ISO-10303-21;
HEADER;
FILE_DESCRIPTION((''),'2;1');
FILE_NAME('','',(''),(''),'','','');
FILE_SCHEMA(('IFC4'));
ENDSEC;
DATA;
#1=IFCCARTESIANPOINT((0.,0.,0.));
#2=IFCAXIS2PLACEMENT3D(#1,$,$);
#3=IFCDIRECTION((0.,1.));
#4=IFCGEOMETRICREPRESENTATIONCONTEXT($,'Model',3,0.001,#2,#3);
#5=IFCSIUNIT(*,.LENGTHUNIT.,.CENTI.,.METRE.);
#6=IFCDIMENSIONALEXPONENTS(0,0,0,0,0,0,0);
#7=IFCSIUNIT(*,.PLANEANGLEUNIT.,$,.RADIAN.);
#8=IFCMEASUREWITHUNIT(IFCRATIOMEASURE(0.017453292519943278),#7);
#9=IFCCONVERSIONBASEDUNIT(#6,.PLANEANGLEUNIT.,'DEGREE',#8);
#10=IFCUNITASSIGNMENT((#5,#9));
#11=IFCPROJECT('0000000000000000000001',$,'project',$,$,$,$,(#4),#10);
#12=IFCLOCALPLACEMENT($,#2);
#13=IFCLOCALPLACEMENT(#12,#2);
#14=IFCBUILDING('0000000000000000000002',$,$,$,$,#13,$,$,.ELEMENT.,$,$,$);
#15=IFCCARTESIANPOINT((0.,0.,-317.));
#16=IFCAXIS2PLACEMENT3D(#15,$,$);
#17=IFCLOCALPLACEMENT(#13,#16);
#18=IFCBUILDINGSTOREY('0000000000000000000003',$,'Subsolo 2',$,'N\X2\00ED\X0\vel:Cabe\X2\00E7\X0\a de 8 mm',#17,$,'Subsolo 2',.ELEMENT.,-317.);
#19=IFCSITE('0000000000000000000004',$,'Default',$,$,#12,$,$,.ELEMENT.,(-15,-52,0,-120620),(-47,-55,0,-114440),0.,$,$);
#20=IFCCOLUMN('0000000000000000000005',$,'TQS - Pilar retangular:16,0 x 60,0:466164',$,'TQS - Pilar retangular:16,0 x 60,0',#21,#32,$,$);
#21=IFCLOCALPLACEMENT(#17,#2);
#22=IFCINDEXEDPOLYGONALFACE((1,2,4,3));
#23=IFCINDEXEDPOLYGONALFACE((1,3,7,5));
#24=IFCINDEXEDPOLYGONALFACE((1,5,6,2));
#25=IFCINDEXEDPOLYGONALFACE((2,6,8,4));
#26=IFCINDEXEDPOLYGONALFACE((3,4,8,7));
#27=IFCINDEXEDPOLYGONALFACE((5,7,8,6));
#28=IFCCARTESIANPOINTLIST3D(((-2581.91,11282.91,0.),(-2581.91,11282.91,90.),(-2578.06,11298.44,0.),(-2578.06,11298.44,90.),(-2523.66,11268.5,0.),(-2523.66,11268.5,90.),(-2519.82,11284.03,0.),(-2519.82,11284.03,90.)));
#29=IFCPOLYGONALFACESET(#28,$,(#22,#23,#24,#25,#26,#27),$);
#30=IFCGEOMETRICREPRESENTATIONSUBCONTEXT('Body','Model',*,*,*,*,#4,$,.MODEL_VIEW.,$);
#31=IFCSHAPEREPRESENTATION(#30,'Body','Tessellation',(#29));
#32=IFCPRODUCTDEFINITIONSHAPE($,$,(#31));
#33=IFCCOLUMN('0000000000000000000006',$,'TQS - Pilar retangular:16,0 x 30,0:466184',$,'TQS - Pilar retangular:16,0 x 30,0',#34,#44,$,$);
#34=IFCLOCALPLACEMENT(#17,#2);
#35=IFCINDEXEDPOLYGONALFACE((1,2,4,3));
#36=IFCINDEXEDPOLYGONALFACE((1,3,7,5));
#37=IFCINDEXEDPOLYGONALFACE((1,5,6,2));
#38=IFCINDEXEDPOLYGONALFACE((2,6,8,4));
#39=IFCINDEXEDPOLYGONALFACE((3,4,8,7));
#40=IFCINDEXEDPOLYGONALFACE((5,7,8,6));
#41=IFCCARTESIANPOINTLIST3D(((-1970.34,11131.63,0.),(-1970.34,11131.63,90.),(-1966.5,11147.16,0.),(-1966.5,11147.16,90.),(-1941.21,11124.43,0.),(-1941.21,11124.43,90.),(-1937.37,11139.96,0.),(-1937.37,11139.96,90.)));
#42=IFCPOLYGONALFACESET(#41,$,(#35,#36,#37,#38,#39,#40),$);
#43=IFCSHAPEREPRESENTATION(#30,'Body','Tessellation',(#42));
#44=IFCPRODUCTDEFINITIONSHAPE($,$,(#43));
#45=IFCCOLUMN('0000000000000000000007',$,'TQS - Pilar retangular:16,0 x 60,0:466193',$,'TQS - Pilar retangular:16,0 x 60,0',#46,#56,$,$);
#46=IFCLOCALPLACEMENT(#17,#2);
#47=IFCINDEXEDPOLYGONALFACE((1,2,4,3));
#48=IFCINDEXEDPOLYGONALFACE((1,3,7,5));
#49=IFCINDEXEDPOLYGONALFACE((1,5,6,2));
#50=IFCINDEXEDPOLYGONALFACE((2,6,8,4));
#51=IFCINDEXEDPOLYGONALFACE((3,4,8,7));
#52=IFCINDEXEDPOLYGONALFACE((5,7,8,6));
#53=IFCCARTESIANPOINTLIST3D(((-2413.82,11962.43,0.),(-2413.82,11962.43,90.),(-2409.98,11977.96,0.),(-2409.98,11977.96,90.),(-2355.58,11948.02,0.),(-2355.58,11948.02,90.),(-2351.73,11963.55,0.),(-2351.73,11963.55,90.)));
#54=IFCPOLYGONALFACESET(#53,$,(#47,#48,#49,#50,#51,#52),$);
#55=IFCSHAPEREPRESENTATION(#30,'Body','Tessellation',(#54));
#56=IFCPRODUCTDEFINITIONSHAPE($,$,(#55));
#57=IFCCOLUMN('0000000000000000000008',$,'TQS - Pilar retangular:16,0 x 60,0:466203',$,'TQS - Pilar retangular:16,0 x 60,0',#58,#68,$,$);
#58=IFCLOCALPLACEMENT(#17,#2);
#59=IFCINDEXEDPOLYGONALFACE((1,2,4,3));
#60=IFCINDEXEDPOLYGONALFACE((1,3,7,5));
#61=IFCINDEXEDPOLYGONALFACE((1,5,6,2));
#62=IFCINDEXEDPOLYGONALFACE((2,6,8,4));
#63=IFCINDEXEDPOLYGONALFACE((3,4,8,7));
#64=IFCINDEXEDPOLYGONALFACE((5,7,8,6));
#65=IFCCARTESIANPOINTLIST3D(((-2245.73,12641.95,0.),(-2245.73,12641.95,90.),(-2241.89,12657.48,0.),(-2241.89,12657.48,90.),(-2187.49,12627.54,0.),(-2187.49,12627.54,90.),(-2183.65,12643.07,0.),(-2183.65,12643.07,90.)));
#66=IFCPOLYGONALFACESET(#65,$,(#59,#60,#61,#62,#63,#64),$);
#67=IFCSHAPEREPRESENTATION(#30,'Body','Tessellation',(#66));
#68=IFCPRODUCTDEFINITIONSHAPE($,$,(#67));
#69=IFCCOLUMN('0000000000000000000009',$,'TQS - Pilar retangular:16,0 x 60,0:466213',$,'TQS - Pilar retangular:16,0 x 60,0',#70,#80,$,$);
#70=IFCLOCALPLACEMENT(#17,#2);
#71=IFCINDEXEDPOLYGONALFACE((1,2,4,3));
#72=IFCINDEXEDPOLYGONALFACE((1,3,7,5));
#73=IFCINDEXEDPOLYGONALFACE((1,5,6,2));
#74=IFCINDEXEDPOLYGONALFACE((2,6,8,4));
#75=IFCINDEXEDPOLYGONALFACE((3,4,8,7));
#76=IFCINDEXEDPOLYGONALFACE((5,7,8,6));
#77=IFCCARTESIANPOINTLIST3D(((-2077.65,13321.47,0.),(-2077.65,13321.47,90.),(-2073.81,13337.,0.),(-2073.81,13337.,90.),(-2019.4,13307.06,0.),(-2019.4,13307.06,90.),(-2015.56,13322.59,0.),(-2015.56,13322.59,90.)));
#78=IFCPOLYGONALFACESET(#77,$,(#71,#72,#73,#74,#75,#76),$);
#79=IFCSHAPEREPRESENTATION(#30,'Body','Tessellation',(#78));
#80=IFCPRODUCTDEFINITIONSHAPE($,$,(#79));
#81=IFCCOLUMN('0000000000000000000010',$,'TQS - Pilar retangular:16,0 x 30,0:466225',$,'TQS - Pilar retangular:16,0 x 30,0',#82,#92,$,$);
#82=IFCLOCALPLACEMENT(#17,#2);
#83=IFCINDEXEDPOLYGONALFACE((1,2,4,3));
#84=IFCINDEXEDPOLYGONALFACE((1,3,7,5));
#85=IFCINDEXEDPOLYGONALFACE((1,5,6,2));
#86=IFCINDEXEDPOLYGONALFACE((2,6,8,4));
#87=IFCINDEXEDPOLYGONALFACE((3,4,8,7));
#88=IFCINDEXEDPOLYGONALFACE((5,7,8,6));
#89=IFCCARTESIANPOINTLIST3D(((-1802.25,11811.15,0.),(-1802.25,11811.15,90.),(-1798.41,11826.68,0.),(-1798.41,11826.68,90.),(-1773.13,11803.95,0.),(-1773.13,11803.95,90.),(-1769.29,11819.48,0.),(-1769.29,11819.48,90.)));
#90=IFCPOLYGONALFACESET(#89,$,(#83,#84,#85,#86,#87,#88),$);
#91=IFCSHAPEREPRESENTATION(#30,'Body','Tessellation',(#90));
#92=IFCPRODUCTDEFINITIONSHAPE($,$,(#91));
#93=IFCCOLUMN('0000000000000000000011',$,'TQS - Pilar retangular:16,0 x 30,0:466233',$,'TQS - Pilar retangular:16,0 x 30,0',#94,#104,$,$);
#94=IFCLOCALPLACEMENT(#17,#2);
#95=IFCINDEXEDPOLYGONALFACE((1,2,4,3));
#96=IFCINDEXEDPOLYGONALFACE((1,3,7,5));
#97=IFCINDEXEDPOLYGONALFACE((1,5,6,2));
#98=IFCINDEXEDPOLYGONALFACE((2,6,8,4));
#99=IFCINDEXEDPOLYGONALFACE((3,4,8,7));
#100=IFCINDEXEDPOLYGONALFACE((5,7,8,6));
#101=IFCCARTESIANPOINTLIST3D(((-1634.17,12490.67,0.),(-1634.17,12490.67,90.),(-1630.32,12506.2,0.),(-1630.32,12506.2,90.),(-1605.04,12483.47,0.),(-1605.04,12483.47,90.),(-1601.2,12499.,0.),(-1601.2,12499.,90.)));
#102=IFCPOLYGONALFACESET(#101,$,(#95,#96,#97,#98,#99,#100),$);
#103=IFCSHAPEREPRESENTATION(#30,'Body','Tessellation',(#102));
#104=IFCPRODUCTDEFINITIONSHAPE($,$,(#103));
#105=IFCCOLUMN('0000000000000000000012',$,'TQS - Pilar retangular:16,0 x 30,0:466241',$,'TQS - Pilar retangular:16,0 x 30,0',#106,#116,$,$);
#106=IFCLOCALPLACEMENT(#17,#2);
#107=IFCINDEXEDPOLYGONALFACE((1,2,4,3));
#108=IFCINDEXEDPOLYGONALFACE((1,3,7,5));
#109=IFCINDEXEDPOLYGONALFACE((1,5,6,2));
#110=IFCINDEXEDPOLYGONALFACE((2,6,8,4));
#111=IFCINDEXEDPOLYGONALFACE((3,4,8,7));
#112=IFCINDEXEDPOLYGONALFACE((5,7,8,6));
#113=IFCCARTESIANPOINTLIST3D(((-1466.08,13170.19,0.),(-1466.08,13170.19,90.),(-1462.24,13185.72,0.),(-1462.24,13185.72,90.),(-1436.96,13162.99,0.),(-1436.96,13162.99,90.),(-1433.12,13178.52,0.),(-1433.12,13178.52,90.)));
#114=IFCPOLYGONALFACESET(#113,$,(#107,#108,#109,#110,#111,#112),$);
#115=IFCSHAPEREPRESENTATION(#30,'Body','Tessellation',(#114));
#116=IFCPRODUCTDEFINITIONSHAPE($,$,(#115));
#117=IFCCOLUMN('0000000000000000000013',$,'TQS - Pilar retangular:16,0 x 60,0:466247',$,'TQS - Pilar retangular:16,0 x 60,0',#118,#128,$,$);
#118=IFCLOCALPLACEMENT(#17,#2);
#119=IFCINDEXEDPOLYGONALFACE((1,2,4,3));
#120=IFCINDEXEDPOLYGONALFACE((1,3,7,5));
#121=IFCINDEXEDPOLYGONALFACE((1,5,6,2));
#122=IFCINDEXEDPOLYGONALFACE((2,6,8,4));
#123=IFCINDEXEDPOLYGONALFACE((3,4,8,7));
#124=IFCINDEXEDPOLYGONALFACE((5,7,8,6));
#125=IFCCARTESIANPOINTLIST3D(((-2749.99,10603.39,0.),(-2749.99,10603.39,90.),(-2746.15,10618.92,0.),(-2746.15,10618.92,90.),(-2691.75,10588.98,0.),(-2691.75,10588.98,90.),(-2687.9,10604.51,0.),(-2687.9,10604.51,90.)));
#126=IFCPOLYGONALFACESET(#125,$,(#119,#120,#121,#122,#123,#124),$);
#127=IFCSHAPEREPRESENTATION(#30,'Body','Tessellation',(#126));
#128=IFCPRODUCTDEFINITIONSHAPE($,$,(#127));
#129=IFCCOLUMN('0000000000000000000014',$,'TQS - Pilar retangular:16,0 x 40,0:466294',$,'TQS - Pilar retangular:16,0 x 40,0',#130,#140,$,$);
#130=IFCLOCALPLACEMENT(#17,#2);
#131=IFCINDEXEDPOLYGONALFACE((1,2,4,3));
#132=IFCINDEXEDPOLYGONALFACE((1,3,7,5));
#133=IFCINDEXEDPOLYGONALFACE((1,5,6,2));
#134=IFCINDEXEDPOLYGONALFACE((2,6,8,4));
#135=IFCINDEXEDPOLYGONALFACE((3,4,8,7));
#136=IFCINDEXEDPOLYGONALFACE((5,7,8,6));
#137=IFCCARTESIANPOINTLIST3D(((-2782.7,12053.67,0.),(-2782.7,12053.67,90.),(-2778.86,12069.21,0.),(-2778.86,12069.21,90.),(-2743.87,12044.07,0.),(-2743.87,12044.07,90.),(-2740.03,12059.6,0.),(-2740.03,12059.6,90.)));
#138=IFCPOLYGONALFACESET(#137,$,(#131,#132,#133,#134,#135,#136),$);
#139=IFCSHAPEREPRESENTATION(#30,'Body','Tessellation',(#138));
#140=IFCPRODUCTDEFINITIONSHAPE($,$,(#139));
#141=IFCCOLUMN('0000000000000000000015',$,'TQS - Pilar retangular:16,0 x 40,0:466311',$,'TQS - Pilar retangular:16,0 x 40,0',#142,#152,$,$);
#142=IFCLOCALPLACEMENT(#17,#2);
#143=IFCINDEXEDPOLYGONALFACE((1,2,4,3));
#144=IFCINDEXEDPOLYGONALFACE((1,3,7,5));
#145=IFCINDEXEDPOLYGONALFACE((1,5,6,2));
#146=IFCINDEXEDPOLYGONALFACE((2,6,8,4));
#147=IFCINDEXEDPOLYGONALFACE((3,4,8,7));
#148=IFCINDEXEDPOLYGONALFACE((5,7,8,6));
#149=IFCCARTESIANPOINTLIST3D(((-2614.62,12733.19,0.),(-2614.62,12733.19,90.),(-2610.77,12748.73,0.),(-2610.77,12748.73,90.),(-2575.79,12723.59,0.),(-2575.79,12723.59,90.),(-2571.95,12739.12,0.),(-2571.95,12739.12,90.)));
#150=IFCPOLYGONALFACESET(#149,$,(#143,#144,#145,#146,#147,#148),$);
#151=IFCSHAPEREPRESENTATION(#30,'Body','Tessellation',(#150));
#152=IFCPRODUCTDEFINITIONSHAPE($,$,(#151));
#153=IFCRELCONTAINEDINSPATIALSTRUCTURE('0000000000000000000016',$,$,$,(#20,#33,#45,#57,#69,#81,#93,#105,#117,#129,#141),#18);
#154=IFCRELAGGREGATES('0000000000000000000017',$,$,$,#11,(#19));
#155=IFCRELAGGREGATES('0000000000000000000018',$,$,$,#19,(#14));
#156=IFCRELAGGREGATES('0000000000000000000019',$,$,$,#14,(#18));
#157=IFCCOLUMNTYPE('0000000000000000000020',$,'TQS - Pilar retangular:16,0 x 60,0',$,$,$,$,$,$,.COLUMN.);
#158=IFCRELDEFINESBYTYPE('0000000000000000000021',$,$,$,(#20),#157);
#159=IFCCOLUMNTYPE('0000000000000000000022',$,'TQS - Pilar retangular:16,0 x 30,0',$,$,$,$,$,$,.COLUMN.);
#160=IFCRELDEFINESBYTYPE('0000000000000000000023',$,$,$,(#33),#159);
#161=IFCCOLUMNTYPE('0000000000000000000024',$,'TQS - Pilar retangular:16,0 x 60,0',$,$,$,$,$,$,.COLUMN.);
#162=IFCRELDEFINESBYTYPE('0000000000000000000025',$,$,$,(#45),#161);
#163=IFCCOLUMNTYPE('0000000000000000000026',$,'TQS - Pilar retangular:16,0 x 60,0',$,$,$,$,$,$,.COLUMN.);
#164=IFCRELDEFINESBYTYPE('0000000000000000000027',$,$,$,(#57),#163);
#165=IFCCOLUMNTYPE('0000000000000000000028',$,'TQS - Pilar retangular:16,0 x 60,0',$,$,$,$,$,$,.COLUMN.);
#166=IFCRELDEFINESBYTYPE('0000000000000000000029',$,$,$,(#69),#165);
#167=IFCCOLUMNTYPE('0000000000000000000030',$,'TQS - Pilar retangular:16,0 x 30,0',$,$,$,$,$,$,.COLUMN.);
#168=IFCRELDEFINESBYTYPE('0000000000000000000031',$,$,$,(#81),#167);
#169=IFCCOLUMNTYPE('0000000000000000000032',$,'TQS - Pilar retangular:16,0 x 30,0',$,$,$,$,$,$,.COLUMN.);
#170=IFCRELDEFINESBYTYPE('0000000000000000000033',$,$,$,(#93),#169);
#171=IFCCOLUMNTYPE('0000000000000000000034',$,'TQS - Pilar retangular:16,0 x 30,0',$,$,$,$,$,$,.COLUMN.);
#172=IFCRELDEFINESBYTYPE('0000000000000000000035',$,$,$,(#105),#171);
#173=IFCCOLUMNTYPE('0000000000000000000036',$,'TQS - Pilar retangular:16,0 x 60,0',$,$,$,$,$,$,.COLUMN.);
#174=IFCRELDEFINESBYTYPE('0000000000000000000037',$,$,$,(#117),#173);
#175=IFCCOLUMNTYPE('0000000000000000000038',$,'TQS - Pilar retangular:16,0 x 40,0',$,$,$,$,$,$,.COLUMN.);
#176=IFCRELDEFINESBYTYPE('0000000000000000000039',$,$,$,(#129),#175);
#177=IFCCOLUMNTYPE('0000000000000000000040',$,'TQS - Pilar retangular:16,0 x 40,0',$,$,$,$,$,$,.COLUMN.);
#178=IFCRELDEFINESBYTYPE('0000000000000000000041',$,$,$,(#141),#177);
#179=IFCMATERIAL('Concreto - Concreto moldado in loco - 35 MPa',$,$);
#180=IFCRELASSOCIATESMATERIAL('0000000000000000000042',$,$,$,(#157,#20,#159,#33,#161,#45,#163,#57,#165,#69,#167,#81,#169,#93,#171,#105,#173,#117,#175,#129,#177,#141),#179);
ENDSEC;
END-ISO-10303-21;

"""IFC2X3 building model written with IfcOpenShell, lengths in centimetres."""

from ifc_helpers import new_model, entity, si_unit, converted_unit, direction, frame, frame_2d, origin, origin_2d_with_axis, place, context, subcontext, project, spatial, rectangle, extrude, source, transform, mapped, material, type_object, type_shapes, element, save


model = new_model("IFC2X3")

# Units and contexts
model_context = context("Model", 3, precision=0.001, world=origin(), true_north=direction((0.0, 1.0)))
body_context = subcontext(model_context, "Body", "Model", "MODEL_VIEW")
ifc_project = project(units=[si_unit("LENGTHUNIT", "METRE", prefix="CENTI"), converted_unit("PLANEANGLEUNIT", "DEGREE", entity("IfcRatioMeasure", 0.017453292519943278), si_unit("PLANEANGLEUNIT", "RADIAN"), dimensions=[0, 0, 0, 0, 0, 0, 0])], contexts=[model_context])

# Site, building, storey
site_placement = place(None, origin())
site = spatial("IfcSite", under=ifc_project, at=site_placement, Name="Default", CompositionType="ELEMENT", RefLatitude=(-15, -52, 0, -120620), RefLongitude=(-47, -55, 0, -114440), RefElevation=0.0)
building_placement = place(site_placement, origin())
building = spatial("IfcBuilding", under=site, at=building_placement, CompositionType="ELEMENT")
storey_placement = place(building_placement, frame((0.0, 0.0, -317.0)))
storey = spatial("IfcBuildingStorey", under=building, at=storey_placement, Name="Subsolo 2", ObjectType="Nível:Cabeça de 8 mm", LongName="Subsolo 2", CompositionType="ELEMENT", Elevation=-317.0)

# Columns
ifc_material = material(Name="Concreto - Concreto moldado in loco - 35 MPa")
column_type_1 = type_object("IfcColumnType", Name="TQS - Pilar retangular:16,0 x 60,0", PredefinedType="COLUMN", material=ifc_material)
shared_shape_1 = source(origin(), body_context, "Body", "SweptSolid", [
    extrude(rectangle(XDim=60.0, YDim=16.0, at=origin_2d_with_axis()), frame((-2550.86, 11283.47, -317.0), z_axis=(0.0, 0.0, 1.0), x_axis=(-0.970743, 0.240122, 0.0)), (0.0, 0.0, 1.0), 90.0),
])
type_shapes(column_type_1, [shared_shape_1])
column_1_placement = place(storey_placement, frame((0.0, 0.0, 317.0)))
element("IfcColumn", 1, at=column_1_placement, inside=storey, type_object=column_type_1, material=ifc_material, Name="TQS - Pilar retangular:16,0 x 60,0:466164", ObjectType="TQS - Pilar retangular:16,0 x 60,0", context=body_context, shape_type="MappedRepresentation", body=[
    mapped(shared_shape_1, transform((0.0, 0.0, 0.0), scale=1.0)),
])
column_type_2 = type_object("IfcColumnType", Name="TQS - Pilar retangular:16,0 x 30,0", PredefinedType="COLUMN", material=ifc_material)
shared_shape_2 = source(origin(), body_context, "Body", "SweptSolid", [
    extrude(rectangle(XDim=30.0, YDim=16.0, at=frame_2d((0.0, 0.0), x_axis=(1.0, 0.0))), frame((-1953.86, 11135.79, -317.0), z_axis=(0.0, 0.0, 1.0), x_axis=(-0.970743, 0.240122, 0.0)), (0.0, 0.0, 1.0), 90.0),
])
type_shapes(column_type_2, [shared_shape_2])
column_2_placement = place(storey_placement, frame((0.0, 0.0, 317.0)))
element("IfcColumn", 2, at=column_2_placement, inside=storey, type_object=column_type_2, material=ifc_material, Name="TQS - Pilar retangular:16,0 x 30,0:466184", ObjectType="TQS - Pilar retangular:16,0 x 30,0", context=body_context, shape_type="MappedRepresentation", body=[
    mapped(shared_shape_2, transform((0.0, 0.0, 0.0), scale=1.0)),
])
column_type_3 = type_object("IfcColumnType", Name="TQS - Pilar retangular:16,0 x 60,0", PredefinedType="COLUMN", material=ifc_material)
shared_shape_3 = source(origin(), body_context, "Body", "SweptSolid", [
    extrude(rectangle(XDim=60.0, YDim=16.0, at=origin_2d_with_axis()), frame((-2382.78, 11962.99, -317.0), z_axis=(0.0, 0.0, 1.0), x_axis=(-0.970743, 0.240122, 0.0)), (0.0, 0.0, 1.0), 90.0),
])
type_shapes(column_type_3, [shared_shape_3])
column_3_placement = place(storey_placement, frame((0.0, 0.0, 317.0)))
element("IfcColumn", 3, at=column_3_placement, inside=storey, type_object=column_type_3, material=ifc_material, Name="TQS - Pilar retangular:16,0 x 60,0:466193", ObjectType="TQS - Pilar retangular:16,0 x 60,0", context=body_context, shape_type="MappedRepresentation", body=[
    mapped(shared_shape_3, transform((0.0, 0.0, 0.0), scale=1.0)),
])
column_type_4 = type_object("IfcColumnType", Name="TQS - Pilar retangular:16,0 x 60,0", PredefinedType="COLUMN", material=ifc_material)
shared_shape_4 = source(origin(), body_context, "Body", "SweptSolid", [
    extrude(rectangle(XDim=60.0, YDim=16.0, at=origin_2d_with_axis()), frame((-2214.69, 12642.51, -317.0), z_axis=(0.0, 0.0, 1.0), x_axis=(-0.970743, 0.240122, 0.0)), (0.0, 0.0, 1.0), 90.0),
])
type_shapes(column_type_4, [shared_shape_4])
column_4_placement = place(storey_placement, frame((0.0, 0.0, 317.0)))
element("IfcColumn", 4, at=column_4_placement, inside=storey, type_object=column_type_4, material=ifc_material, Name="TQS - Pilar retangular:16,0 x 60,0:466203", ObjectType="TQS - Pilar retangular:16,0 x 60,0", context=body_context, shape_type="MappedRepresentation", body=[
    mapped(shared_shape_4, transform((0.0, 0.0, 0.0), scale=1.0)),
])
column_type_5 = type_object("IfcColumnType", Name="TQS - Pilar retangular:16,0 x 60,0", PredefinedType="COLUMN", material=ifc_material)
shared_shape_5 = source(origin(), body_context, "Body", "SweptSolid", [
    extrude(rectangle(XDim=60.0, YDim=16.0, at=origin_2d_with_axis()), frame((-2046.61, 13322.03, -317.0), z_axis=(0.0, 0.0, 1.0), x_axis=(-0.970743, 0.240122, 0.0)), (0.0, 0.0, 1.0), 90.0),
])
type_shapes(column_type_5, [shared_shape_5])
column_5_placement = place(storey_placement, frame((0.0, 0.0, 317.0)))
element("IfcColumn", 5, at=column_5_placement, inside=storey, type_object=column_type_5, material=ifc_material, Name="TQS - Pilar retangular:16,0 x 60,0:466213", ObjectType="TQS - Pilar retangular:16,0 x 60,0", context=body_context, shape_type="MappedRepresentation", body=[
    mapped(shared_shape_5, transform((0.0, 0.0, 0.0), scale=1.0)),
])
column_type_6 = type_object("IfcColumnType", Name="TQS - Pilar retangular:16,0 x 30,0", PredefinedType="COLUMN", material=ifc_material)
shared_shape_6 = source(origin(), body_context, "Body", "SweptSolid", [
    extrude(rectangle(XDim=30.0, YDim=16.0, at=origin_2d_with_axis()), frame((-1785.77, 11815.31, -317.0), z_axis=(0.0, 0.0, 1.0), x_axis=(-0.970743, 0.240122, 0.0)), (0.0, 0.0, 1.0), 90.0),
])
type_shapes(column_type_6, [shared_shape_6])
column_6_placement = place(storey_placement, frame((0.0, 0.0, 317.0)))
element("IfcColumn", 6, at=column_6_placement, inside=storey, type_object=column_type_6, material=ifc_material, Name="TQS - Pilar retangular:16,0 x 30,0:466225", ObjectType="TQS - Pilar retangular:16,0 x 30,0", context=body_context, shape_type="MappedRepresentation", body=[
    mapped(shared_shape_6, transform((0.0, 0.0, 0.0), scale=1.0)),
])
column_type_7 = type_object("IfcColumnType", Name="TQS - Pilar retangular:16,0 x 30,0", PredefinedType="COLUMN", material=ifc_material)
shared_shape_7 = source(origin(), body_context, "Body", "SweptSolid", [
    extrude(rectangle(XDim=30.0, YDim=16.0, at=origin_2d_with_axis()), frame((-1617.68, 12494.83, -317.0), z_axis=(0.0, 0.0, 1.0), x_axis=(-0.970743, 0.240122, 0.0)), (0.0, 0.0, 1.0), 90.0),
])
type_shapes(column_type_7, [shared_shape_7])
column_7_placement = place(storey_placement, frame((0.0, 0.0, 317.0)))
element("IfcColumn", 7, at=column_7_placement, inside=storey, type_object=column_type_7, material=ifc_material, Name="TQS - Pilar retangular:16,0 x 30,0:466233", ObjectType="TQS - Pilar retangular:16,0 x 30,0", context=body_context, shape_type="MappedRepresentation", body=[
    mapped(shared_shape_7, transform((0.0, 0.0, 0.0), scale=1.0)),
])
column_type_8 = type_object("IfcColumnType", Name="TQS - Pilar retangular:16,0 x 30,0", PredefinedType="COLUMN", material=ifc_material)
shared_shape_8 = source(origin(), body_context, "Body", "SweptSolid", [
    extrude(rectangle(XDim=30.0, YDim=16.0, at=origin_2d_with_axis()), frame((-1449.6, 13174.35, -317.0), z_axis=(0.0, 0.0, 1.0), x_axis=(-0.970743, 0.240122, 0.0)), (0.0, 0.0, 1.0), 90.0),
])
type_shapes(column_type_8, [shared_shape_8])
column_8_placement = place(storey_placement, frame((0.0, 0.0, 317.0)))
element("IfcColumn", 8, at=column_8_placement, inside=storey, type_object=column_type_8, material=ifc_material, Name="TQS - Pilar retangular:16,0 x 30,0:466241", ObjectType="TQS - Pilar retangular:16,0 x 30,0", context=body_context, shape_type="MappedRepresentation", body=[
    mapped(shared_shape_8, transform((0.0, 0.0, 0.0), scale=1.0)),
])
column_type_9 = type_object("IfcColumnType", Name="TQS - Pilar retangular:16,0 x 60,0", PredefinedType="COLUMN", material=ifc_material)
shared_shape_9 = source(origin(), body_context, "Body", "SweptSolid", [
    extrude(rectangle(XDim=60.0, YDim=16.0, at=origin_2d_with_axis()), frame((-2718.95, 10603.95, -317.0), z_axis=(0.0, 0.0, 1.0), x_axis=(-0.970743, 0.240122, 0.0)), (0.0, 0.0, 1.0), 90.0),
])
type_shapes(column_type_9, [shared_shape_9])
column_9_placement = place(storey_placement, frame((0.0, 0.0, 317.0)))
element("IfcColumn", 9, at=column_9_placement, inside=storey, type_object=column_type_9, material=ifc_material, Name="TQS - Pilar retangular:16,0 x 60,0:466247", ObjectType="TQS - Pilar retangular:16,0 x 60,0", context=body_context, shape_type="MappedRepresentation", body=[
    mapped(shared_shape_9, transform((0.0, 0.0, 0.0), scale=1.0)),
])
column_type_10 = type_object("IfcColumnType", Name="TQS - Pilar retangular:16,0 x 40,0", PredefinedType="COLUMN", material=ifc_material)
shared_shape_10 = source(origin(), body_context, "Body", "SweptSolid", [
    extrude(rectangle(XDim=40.0, YDim=16.0, at=origin_2d_with_axis()), frame((-2761.37, 12056.64, -317.0), z_axis=(0.0, 0.0, 1.0), x_axis=(-0.970743, 0.240122, 0.0)), (0.0, 0.0, 1.0), 90.0),
])
type_shapes(column_type_10, [shared_shape_10])
column_10_placement = place(storey_placement, frame((0.0, 0.0, 317.0)))
element("IfcColumn", 10, at=column_10_placement, inside=storey, type_object=column_type_10, material=ifc_material, Name="TQS - Pilar retangular:16,0 x 40,0:466294", ObjectType="TQS - Pilar retangular:16,0 x 40,0", context=body_context, shape_type="MappedRepresentation", body=[
    mapped(shared_shape_10, transform((0.0, 0.0, 0.0), scale=1.0)),
])
column_type_11 = type_object("IfcColumnType", Name="TQS - Pilar retangular:16,0 x 40,0", PredefinedType="COLUMN", material=ifc_material)
shared_shape_11 = source(origin(), body_context, "Body", "SweptSolid", [
    extrude(rectangle(XDim=40.0, YDim=16.0, at=origin_2d_with_axis()), frame((-2593.28, 12736.16, -317.0), z_axis=(0.0, 0.0, 1.0), x_axis=(-0.970743, 0.240122, 0.0)), (0.0, 0.0, 1.0), 90.0),
])
type_shapes(column_type_11, [shared_shape_11])
column_11_placement = place(storey_placement, frame((0.0, 0.0, 317.0)))
element("IfcColumn", 11, at=column_11_placement, inside=storey, type_object=column_type_11, material=ifc_material, Name="TQS - Pilar retangular:16,0 x 40,0:466311", ObjectType="TQS - Pilar retangular:16,0 x 40,0", context=body_context, shape_type="MappedRepresentation", body=[
    mapped(shared_shape_11, transform((0.0, 0.0, 0.0), scale=1.0)),
])

save(model, "model.ifc")
